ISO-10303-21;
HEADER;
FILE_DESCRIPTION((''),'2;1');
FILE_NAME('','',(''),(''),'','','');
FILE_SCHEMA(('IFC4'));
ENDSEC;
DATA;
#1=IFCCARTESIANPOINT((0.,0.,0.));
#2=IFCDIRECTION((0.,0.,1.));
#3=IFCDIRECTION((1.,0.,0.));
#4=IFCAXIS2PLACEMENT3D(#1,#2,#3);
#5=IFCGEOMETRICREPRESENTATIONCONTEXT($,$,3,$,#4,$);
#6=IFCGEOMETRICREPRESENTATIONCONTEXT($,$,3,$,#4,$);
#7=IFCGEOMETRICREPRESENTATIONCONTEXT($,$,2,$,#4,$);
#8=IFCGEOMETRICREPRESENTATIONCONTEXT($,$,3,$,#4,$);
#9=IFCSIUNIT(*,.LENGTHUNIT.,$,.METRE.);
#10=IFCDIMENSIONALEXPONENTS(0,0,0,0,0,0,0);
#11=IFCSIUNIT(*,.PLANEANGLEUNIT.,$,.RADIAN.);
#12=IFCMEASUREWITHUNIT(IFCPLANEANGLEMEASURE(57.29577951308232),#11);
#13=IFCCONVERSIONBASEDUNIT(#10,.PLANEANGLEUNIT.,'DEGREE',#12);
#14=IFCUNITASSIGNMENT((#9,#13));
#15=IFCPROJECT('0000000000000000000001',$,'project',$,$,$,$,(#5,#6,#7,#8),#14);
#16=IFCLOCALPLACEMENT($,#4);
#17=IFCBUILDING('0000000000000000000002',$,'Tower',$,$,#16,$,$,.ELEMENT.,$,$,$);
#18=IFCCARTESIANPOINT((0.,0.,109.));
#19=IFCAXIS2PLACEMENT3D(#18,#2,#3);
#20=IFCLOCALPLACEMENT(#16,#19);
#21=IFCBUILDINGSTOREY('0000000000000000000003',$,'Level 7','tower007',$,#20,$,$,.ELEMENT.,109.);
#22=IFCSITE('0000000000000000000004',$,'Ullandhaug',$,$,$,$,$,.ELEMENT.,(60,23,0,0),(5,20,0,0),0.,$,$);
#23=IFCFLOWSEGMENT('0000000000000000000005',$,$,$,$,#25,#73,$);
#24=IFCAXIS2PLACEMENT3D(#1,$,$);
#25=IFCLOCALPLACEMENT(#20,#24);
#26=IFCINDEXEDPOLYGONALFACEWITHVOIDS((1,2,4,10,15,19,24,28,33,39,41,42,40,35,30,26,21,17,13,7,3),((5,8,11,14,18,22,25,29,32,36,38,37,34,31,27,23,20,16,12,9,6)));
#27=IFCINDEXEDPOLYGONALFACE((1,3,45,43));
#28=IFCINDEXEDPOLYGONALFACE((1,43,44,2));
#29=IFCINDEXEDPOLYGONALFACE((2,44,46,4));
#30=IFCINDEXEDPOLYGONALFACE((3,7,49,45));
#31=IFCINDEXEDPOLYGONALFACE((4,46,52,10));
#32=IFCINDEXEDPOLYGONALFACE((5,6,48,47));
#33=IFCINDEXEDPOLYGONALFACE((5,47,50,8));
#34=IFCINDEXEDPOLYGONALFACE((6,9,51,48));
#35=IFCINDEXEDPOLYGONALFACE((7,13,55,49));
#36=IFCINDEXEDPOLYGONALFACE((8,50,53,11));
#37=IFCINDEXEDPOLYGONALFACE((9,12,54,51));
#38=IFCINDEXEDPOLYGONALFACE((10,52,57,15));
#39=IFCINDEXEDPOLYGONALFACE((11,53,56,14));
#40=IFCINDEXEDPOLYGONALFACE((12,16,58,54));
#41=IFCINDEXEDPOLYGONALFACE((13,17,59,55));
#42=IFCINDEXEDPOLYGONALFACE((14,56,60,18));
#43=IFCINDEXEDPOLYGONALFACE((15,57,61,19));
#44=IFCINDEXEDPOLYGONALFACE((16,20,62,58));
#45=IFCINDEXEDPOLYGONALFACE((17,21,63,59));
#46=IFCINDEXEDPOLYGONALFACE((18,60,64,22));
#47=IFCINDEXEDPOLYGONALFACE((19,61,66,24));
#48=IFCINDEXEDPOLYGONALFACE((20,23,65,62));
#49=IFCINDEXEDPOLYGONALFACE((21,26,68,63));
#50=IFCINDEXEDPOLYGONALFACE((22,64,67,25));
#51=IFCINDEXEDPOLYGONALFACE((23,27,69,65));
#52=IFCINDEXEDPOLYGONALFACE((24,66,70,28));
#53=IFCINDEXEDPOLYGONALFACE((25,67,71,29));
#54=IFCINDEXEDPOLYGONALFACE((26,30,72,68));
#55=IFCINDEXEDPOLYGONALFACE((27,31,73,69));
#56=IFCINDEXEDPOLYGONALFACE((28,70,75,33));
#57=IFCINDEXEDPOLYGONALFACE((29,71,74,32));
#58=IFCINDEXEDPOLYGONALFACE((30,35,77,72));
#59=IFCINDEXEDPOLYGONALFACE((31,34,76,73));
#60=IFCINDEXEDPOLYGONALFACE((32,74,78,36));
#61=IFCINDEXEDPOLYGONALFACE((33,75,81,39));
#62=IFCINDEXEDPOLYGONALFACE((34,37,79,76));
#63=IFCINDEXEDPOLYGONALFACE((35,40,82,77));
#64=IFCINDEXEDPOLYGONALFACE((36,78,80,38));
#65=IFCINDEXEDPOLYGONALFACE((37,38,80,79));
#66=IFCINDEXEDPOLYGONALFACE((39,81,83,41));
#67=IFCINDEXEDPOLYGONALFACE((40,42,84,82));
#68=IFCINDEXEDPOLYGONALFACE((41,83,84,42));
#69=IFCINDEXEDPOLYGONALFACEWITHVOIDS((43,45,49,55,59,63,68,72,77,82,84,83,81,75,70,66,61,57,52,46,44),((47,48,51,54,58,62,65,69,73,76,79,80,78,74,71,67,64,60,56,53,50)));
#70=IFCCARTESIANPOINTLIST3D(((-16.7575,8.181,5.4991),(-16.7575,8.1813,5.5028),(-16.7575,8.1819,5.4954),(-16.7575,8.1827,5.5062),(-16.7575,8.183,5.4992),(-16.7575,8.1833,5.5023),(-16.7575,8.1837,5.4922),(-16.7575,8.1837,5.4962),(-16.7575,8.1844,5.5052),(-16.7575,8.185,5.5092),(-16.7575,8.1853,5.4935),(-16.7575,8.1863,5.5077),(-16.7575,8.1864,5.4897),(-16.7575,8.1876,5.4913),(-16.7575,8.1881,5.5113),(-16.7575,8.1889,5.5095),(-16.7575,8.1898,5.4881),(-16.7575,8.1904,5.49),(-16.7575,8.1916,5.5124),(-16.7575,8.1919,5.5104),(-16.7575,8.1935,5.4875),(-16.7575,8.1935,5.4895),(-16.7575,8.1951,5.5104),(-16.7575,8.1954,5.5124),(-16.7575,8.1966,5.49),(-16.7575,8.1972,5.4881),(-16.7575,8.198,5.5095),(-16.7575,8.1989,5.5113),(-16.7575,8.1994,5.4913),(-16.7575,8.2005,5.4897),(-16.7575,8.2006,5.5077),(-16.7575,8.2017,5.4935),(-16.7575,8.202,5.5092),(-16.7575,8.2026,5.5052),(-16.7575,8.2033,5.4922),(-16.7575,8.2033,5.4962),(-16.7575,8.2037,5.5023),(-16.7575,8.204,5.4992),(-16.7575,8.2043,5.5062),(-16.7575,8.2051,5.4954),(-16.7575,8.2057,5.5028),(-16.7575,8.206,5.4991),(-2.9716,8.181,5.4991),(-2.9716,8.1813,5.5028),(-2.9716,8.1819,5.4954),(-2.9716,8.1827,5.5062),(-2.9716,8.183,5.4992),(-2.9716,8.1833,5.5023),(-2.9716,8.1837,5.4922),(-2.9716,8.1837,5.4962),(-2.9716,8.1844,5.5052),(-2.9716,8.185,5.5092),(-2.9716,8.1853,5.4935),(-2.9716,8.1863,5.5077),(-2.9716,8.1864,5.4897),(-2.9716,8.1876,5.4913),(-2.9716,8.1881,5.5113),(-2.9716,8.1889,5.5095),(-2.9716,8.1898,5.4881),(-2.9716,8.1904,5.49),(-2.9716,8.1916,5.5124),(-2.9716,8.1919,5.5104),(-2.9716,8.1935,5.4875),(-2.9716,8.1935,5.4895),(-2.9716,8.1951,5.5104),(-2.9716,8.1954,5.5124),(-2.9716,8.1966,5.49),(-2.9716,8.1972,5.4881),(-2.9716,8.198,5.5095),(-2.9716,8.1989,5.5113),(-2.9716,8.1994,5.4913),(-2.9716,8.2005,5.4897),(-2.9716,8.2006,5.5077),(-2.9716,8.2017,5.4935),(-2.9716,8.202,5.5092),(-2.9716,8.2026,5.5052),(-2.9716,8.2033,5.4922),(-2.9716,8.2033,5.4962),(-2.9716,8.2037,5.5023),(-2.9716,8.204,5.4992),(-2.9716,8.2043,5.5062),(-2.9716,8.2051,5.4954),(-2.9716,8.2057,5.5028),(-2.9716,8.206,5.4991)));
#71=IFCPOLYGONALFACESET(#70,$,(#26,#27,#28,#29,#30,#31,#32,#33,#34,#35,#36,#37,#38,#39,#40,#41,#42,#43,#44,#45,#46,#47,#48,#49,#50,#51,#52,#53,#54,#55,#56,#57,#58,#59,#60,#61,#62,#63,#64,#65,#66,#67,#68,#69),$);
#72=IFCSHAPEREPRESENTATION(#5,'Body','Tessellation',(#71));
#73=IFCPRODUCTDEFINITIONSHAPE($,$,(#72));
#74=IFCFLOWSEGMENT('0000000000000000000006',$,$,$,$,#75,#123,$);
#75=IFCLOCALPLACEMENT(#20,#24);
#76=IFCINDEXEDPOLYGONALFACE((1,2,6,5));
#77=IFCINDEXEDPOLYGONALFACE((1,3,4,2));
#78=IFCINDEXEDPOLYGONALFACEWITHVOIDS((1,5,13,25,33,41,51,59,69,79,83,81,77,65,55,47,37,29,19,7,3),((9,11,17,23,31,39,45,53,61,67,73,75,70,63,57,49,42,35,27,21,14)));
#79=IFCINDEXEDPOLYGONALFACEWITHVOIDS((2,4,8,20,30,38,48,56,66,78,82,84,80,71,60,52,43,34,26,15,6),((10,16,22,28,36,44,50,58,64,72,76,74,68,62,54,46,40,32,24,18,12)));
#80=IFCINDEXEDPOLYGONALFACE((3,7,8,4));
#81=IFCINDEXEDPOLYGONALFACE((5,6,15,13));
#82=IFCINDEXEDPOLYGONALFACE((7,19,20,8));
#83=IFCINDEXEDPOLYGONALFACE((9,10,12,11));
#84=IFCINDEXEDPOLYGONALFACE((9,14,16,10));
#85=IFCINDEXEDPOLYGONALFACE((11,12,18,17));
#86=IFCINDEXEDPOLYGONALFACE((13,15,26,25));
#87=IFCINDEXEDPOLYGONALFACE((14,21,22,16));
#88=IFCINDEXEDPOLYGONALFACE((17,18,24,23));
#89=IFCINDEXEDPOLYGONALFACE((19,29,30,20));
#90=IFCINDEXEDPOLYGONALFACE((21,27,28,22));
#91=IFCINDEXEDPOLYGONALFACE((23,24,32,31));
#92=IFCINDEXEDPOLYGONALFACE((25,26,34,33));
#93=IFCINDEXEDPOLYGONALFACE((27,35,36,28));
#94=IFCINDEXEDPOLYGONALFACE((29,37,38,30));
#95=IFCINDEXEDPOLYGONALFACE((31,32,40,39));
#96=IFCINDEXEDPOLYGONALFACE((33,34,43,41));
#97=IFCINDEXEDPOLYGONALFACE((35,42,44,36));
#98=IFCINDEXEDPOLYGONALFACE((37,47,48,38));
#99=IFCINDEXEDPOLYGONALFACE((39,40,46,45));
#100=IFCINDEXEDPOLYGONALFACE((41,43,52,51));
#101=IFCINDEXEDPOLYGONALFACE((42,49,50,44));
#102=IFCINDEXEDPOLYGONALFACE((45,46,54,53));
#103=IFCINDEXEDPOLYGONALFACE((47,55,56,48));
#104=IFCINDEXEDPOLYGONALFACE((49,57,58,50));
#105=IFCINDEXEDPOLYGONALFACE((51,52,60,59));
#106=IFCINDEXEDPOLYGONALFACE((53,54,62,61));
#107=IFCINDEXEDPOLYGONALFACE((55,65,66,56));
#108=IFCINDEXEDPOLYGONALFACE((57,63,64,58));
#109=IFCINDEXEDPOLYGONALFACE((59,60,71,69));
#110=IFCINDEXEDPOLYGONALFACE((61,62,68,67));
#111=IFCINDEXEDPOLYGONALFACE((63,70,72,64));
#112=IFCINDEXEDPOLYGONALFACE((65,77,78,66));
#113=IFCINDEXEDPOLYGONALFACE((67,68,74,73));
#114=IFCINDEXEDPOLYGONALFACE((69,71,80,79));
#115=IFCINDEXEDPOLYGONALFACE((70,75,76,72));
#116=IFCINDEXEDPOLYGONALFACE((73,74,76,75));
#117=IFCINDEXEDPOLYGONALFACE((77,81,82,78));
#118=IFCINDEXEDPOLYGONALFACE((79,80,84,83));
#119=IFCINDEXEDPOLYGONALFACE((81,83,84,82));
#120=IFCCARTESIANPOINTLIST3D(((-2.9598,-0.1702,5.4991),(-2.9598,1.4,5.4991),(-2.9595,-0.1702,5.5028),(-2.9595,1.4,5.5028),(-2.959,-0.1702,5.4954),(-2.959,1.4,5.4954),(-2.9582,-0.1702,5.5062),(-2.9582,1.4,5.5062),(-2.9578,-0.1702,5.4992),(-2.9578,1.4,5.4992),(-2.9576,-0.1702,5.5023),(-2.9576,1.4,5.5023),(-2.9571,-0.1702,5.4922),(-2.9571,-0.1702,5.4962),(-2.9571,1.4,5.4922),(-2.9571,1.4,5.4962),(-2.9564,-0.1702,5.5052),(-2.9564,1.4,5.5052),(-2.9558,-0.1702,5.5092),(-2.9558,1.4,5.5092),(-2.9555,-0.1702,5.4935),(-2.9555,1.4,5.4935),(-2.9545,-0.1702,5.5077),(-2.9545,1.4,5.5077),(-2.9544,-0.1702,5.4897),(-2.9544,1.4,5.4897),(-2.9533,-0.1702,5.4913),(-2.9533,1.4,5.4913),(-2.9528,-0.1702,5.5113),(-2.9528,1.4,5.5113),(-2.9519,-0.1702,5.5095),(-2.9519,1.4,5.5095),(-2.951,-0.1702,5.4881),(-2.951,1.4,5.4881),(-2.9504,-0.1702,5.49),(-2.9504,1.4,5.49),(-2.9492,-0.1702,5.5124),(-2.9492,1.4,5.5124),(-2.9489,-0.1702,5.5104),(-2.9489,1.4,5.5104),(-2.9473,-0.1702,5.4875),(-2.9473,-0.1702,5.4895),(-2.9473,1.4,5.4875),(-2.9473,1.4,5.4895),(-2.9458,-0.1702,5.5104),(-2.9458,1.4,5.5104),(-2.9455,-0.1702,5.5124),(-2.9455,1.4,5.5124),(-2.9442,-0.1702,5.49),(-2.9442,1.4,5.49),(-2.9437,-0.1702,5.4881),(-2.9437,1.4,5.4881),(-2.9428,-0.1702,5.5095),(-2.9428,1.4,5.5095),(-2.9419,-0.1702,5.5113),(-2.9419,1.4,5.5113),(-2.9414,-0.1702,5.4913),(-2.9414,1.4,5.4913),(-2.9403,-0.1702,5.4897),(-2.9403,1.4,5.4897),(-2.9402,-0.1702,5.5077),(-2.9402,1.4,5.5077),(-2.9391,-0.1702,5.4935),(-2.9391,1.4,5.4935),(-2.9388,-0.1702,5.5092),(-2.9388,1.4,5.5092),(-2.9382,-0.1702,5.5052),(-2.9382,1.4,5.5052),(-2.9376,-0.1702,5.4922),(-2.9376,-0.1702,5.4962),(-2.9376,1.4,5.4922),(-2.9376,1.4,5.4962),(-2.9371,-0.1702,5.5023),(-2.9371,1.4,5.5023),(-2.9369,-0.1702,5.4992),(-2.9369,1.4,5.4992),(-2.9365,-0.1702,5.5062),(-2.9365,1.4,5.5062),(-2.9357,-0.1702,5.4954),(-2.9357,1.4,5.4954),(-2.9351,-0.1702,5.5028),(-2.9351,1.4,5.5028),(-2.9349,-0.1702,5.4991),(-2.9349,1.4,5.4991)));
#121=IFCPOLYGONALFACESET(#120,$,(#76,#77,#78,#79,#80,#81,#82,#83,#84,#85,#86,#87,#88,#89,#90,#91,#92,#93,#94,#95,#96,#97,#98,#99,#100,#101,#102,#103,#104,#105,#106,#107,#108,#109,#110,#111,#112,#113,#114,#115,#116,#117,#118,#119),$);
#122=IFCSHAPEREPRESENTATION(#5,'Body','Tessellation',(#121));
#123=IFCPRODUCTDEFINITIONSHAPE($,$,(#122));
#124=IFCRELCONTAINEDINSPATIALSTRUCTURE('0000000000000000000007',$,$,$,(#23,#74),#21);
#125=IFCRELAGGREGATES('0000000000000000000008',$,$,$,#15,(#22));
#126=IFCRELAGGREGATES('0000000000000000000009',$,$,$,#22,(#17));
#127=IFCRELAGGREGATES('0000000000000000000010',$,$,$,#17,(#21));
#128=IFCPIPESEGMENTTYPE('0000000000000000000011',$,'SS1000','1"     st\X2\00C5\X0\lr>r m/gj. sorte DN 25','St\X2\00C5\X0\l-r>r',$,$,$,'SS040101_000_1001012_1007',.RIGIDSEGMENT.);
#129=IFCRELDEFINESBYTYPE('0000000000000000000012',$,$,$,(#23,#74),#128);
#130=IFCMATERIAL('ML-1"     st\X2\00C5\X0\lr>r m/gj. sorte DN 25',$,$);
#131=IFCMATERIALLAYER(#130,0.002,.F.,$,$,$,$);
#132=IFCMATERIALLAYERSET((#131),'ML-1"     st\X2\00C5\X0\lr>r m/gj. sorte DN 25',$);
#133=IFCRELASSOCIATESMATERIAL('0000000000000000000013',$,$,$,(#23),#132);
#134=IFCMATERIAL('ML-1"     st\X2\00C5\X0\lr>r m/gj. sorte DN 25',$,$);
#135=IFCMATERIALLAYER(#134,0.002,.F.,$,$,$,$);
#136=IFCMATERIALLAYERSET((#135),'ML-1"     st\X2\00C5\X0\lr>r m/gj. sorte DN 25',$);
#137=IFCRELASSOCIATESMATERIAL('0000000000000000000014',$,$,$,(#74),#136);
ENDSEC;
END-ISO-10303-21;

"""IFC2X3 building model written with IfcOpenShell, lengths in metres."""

from ifc_helpers import new_model, entity, si_unit, converted_unit, frame, origin_with_axes, origin_2d_with_axis, place, context, project, spatial, hollow_circle, extrude, material, layer, layer_set, layer_usage, type_object, element, save


model = new_model("IFC2X3")

# Units and contexts
context_of_model_1 = context(None, 3, world=origin_with_axes())
context_of_model_2 = context(None, 3, world=origin_with_axes())
context_of_model_3 = context(None, 2, world=origin_with_axes())
context_of_model_4 = context(None, 3, world=origin_with_axes())
ifc_project = project(units=[si_unit("LENGTHUNIT", "METRE"), converted_unit("PLANEANGLEUNIT", "DEGREE", entity("IfcPlaneAngleMeasure", 57.29577951308232), si_unit("PLANEANGLEUNIT", "RADIAN"), dimensions=[0, 0, 0, 0, 0, 0, 0])], contexts=[context_of_model_1, context_of_model_2, context_of_model_3, context_of_model_4])

# Site, building, storey
site = spatial("IfcSite", under=ifc_project, Name="Ullandhaug", CompositionType="ELEMENT", RefLatitude=(60, 23, 0, 0), RefLongitude=(5, 20, 0, 0), RefElevation=0.0)
building_placement = place(None, origin_with_axes())
building = spatial("IfcBuilding", under=site, at=building_placement, Name="Tower", CompositionType="ELEMENT")
storey_placement = place(building_placement, frame((0.0, 0.0, 109.0), z_axis=(0.0, 0.0, 1.0), x_axis=(1.0, 0.0, 0.0)))
storey = spatial("IfcBuildingStorey", under=building, at=storey_placement, Name="Level 7", Description="tower007", CompositionType="ELEMENT", Elevation=109.0)

# Flow segments
pipe_segment_type_1 = type_object("IfcPipeSegmentType", Name="SS1000", Description="1\"     stÅlr>r m/gj. sorte DN 25", ApplicableOccurrence="StÅl-r>r", ElementType="SS040101_000_1001012_1007", PredefinedType="RIGIDSEGMENT")
ifc_material_1 = material(Name="ML-1\"     stÅlr>r m/gj. sorte DN 25")
ifc_layer_1 = layer(ifc_material_1, 0.002, ventilated=False)
ifc_layer_set_1 = layer_set([ifc_layer_1], Name="ML-1\"     stÅlr>r m/gj. sorte DN 25")
ifc_layer_usage_1 = layer_usage(ifc_layer_set_1, "AXIS2", "POSITIVE", 0.0)
flow_segment_1_placement = place(storey_placement, frame((-2.9716, 8.1935, 5.5), z_axis=(-1.0, 0.0, 0.0), x_axis=(0.0, 0.0, -1.0)))
element("IfcFlowSegment", 1, at=flow_segment_1_placement, inside=storey, type_object=pipe_segment_type_1, material=ifc_layer_usage_1, context=context_of_model_1, shape_type="SweptSolid", body=[
    extrude(hollow_circle(Radius=0.0125, WallThickness=0.002, at=origin_2d_with_axis()), origin_with_axes(), (0.0, 0.0, 1.0), 13.7859),
])
ifc_material_2 = material(Name="ML-1\"     stÅlr>r m/gj. sorte DN 25")
ifc_layer_2 = layer(ifc_material_2, 0.002, ventilated=False)
ifc_layer_set_2 = layer_set([ifc_layer_2], Name="ML-1\"     stÅlr>r m/gj. sorte DN 25")
ifc_layer_usage_2 = layer_usage(ifc_layer_set_2, "AXIS2", "POSITIVE", 0.0)
flow_segment_2_placement = place(storey_placement, frame((-2.9473, -0.1702, 5.5), z_axis=(0.0, 1.0, 0.0), x_axis=(0.0, 0.0, -1.0)))
element("IfcFlowSegment", 2, at=flow_segment_2_placement, inside=storey, type_object=pipe_segment_type_1, material=ifc_layer_usage_2, context=context_of_model_1, shape_type="SweptSolid", body=[
    extrude(hollow_circle(Radius=0.0125, WallThickness=0.002, at=origin_2d_with_axis()), origin_with_axes(), (0.0, 0.0, 1.0), 1.5702),
])

save(model, "model.ifc")
